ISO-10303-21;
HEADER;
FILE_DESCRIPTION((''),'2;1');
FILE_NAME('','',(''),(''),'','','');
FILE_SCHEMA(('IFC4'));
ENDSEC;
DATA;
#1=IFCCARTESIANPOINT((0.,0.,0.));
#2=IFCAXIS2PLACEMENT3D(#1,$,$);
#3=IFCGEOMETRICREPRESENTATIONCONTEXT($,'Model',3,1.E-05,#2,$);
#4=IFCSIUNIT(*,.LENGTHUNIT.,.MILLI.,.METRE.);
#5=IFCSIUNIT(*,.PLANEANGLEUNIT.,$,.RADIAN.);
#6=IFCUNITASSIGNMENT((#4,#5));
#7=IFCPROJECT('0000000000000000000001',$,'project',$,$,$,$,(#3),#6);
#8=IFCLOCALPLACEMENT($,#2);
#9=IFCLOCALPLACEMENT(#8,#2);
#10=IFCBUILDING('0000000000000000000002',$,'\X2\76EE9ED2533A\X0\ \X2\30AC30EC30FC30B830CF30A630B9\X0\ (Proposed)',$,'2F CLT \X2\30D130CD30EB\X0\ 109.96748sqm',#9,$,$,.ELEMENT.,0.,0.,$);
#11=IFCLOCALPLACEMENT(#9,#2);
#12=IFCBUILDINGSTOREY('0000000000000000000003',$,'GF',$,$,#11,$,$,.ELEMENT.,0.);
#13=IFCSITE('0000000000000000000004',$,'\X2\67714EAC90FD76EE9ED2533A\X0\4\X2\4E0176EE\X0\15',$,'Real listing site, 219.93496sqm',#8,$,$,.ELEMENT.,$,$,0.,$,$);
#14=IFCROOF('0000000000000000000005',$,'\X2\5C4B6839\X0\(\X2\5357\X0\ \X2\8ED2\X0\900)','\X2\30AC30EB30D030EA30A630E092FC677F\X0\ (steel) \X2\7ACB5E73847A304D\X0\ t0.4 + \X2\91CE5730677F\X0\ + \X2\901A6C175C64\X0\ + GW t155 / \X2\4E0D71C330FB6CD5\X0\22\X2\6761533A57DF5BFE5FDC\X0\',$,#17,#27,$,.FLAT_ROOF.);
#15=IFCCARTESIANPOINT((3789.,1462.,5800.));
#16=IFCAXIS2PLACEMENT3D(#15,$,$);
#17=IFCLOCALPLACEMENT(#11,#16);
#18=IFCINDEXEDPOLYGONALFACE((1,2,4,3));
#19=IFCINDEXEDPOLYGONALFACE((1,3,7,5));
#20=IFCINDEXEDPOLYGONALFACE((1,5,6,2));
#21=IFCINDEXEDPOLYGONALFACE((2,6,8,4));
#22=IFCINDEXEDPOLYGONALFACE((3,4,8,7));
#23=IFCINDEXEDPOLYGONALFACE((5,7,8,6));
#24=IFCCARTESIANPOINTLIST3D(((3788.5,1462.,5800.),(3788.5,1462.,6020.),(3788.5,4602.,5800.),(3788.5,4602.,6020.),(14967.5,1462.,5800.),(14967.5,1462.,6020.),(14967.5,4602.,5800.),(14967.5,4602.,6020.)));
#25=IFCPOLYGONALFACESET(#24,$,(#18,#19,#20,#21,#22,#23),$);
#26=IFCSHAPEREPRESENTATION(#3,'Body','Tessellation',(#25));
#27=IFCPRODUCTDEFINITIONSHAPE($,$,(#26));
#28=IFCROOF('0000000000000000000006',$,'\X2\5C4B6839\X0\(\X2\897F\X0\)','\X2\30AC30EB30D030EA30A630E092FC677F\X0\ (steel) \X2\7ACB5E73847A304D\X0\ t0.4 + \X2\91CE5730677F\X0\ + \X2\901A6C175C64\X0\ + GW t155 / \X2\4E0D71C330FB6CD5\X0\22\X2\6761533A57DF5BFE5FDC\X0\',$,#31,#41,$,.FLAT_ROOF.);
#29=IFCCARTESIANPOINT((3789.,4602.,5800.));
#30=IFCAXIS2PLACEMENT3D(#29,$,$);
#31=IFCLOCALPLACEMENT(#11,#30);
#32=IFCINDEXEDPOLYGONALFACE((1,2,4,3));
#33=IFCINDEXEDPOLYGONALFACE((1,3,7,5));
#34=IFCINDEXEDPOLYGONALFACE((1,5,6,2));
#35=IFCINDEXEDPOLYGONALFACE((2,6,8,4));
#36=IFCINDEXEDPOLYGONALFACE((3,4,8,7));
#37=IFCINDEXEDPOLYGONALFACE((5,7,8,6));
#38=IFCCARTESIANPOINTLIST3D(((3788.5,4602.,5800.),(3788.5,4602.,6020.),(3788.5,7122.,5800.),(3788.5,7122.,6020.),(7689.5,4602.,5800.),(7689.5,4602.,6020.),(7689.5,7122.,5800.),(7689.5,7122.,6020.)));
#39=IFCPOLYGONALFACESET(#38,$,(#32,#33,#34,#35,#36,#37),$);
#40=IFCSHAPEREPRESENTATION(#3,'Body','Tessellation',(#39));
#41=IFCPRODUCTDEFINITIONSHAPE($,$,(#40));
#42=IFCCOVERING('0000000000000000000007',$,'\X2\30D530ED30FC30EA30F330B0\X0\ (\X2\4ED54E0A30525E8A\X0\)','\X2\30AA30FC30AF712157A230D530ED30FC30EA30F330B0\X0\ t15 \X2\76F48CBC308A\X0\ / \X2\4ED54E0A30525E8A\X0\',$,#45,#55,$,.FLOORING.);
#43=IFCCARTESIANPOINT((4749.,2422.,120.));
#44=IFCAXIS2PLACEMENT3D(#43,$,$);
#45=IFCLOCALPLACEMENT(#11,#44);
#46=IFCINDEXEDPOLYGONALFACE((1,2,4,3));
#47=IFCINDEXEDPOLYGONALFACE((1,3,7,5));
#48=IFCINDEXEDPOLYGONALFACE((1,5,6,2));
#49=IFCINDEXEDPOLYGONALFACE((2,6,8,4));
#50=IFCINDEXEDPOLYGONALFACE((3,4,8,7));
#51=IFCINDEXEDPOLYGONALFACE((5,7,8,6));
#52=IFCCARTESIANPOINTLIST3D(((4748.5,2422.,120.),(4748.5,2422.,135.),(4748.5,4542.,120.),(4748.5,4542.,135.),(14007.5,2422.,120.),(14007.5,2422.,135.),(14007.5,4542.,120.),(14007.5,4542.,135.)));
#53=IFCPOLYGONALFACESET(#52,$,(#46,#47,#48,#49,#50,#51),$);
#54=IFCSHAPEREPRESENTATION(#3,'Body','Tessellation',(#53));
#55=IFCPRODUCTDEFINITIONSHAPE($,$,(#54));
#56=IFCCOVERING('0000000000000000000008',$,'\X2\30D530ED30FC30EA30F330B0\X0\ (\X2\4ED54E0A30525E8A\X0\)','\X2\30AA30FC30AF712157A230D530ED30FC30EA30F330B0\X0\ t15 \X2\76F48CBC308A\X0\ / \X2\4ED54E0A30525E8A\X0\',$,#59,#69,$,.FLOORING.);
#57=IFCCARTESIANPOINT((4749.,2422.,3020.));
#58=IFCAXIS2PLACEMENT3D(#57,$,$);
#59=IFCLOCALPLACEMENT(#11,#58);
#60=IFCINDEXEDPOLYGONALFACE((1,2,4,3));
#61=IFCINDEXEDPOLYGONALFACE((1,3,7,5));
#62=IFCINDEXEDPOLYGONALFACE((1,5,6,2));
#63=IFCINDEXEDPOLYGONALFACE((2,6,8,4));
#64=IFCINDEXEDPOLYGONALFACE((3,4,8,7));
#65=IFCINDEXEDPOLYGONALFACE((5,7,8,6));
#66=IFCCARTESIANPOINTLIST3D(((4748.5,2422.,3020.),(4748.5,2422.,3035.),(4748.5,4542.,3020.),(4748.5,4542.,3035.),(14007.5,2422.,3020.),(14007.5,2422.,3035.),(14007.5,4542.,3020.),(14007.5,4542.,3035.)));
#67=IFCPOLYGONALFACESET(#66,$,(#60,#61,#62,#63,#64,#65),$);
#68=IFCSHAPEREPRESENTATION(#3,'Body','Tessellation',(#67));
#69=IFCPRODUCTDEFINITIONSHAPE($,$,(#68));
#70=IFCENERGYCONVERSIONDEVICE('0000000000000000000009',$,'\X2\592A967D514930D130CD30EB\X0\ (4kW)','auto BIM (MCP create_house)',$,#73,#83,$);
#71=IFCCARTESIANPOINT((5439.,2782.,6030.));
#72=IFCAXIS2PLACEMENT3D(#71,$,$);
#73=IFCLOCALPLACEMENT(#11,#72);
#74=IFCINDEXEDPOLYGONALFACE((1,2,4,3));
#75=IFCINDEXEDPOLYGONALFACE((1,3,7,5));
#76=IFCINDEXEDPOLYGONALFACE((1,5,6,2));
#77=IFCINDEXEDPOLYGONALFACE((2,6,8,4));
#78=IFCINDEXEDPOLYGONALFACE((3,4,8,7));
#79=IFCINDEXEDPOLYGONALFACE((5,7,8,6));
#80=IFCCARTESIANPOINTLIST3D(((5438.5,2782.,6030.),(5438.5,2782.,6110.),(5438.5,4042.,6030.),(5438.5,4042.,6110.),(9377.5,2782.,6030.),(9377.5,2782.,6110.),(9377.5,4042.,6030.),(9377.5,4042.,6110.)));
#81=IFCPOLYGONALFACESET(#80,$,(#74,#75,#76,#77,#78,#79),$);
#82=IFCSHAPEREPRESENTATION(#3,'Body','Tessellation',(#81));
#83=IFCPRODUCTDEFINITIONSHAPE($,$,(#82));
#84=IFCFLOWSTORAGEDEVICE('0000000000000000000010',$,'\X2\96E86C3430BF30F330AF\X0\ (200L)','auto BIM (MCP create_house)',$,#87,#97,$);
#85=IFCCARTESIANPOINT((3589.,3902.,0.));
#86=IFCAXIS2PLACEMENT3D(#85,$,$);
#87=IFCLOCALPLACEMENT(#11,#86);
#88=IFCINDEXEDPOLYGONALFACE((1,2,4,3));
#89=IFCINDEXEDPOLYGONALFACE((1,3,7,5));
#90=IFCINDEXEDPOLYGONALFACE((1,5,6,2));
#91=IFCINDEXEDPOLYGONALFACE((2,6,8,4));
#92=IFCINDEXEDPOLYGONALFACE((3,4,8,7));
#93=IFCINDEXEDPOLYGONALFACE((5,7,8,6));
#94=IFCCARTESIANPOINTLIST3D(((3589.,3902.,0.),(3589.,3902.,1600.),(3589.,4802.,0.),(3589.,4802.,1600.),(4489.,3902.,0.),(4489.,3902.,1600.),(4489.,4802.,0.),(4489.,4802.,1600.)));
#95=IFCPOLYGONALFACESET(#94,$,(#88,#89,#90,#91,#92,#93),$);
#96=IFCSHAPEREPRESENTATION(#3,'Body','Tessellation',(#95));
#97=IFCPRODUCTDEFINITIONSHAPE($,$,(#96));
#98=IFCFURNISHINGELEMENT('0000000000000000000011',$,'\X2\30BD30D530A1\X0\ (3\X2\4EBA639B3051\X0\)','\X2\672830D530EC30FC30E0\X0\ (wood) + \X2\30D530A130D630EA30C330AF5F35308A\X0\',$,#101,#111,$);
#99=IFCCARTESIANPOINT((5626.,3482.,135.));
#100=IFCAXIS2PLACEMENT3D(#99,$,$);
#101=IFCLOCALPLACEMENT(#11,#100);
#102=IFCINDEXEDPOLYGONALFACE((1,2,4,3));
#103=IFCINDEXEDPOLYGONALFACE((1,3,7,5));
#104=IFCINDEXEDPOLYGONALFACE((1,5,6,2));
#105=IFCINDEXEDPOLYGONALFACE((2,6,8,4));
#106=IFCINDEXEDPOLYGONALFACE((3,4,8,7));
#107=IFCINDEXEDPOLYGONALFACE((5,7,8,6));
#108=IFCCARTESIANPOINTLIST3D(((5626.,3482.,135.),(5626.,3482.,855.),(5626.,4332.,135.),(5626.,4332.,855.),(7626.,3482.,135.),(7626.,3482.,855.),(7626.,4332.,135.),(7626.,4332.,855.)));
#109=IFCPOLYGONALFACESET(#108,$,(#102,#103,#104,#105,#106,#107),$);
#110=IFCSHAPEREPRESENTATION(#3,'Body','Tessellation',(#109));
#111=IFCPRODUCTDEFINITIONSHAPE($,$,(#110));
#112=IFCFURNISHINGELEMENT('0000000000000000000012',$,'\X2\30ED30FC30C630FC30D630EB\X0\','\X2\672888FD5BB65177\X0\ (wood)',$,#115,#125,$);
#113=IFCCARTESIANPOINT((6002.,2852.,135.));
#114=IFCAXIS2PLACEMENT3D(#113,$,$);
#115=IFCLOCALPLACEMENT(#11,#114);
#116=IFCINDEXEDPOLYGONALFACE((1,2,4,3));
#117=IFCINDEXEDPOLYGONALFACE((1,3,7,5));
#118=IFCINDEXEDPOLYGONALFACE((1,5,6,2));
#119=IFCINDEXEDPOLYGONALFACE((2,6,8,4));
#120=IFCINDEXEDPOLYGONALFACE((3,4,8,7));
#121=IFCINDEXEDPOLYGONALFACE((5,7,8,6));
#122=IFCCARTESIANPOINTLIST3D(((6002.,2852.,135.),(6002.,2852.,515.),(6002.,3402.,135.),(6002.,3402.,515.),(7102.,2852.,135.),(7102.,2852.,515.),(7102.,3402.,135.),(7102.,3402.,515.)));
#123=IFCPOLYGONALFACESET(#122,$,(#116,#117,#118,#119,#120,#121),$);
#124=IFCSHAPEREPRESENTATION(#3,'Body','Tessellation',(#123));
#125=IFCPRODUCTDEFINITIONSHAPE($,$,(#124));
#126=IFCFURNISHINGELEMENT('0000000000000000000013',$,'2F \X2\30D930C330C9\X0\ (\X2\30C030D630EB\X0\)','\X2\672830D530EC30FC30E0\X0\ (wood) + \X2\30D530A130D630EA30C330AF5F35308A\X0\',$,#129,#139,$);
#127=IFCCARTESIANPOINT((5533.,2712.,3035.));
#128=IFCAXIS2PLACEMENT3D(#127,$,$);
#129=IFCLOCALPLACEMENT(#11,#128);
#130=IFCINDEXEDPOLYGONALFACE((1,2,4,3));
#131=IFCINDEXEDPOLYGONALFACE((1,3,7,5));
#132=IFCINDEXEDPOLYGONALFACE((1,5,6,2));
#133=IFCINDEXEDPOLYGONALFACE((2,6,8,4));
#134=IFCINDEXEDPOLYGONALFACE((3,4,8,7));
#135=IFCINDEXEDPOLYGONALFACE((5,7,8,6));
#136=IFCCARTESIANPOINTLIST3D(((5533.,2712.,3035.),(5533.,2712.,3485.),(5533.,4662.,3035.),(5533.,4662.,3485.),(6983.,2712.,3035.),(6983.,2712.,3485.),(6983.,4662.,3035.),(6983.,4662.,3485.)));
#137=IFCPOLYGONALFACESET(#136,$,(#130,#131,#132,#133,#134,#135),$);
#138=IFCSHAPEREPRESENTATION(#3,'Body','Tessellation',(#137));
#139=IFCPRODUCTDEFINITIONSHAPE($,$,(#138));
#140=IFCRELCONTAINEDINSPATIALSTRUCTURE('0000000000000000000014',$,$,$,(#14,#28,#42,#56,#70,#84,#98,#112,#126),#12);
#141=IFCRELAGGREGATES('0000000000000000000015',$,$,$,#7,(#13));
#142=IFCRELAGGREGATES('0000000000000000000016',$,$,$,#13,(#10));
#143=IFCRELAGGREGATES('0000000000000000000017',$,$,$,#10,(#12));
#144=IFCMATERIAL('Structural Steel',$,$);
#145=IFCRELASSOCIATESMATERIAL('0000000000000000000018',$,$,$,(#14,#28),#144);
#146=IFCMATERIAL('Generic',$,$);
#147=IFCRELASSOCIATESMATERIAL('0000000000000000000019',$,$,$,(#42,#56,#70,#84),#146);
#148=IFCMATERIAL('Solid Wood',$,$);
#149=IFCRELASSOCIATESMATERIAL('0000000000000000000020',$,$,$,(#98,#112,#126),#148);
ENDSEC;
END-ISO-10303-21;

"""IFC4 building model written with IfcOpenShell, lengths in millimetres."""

from ifc_helpers import new_model, si_unit, frame, frame_2d, origin, place, context, project, spatial, rectangle, extrude, material, element, save


model = new_model("IFC4")

# Units and contexts
model_context = context("Model", 3, precision=1e-05, world=origin())
ifc_project = project(units=[si_unit("LENGTHUNIT", "METRE", prefix="MILLI"), si_unit("PLANEANGLEUNIT", "RADIAN")], contexts=[model_context])

# Site, building, storey
site_placement = place(None, origin())
site = spatial("IfcSite", under=ifc_project, at=site_placement, Name="東京都目黒区4丁目15", ObjectType="Real listing site, 219.93496sqm", CompositionType="ELEMENT", RefElevation=0.0)
building_placement = place(site_placement, origin())
building = spatial("IfcBuilding", under=site, at=building_placement, Name="目黒区 ガレージハウス (Proposed)", ObjectType="2F CLT パネル 109.96748sqm", CompositionType="ELEMENT", ElevationOfRefHeight=0.0, ElevationOfTerrain=0.0)
storey_placement = place(building_placement, origin())
storey = spatial("IfcBuildingStorey", under=building, at=storey_placement, Name="GF", CompositionType="ELEMENT", Elevation=0.0)

# Shared definitions
ifc_material_1 = material(Name="Solid Wood")

# Roofs
ifc_material_2 = material(Name="Structural Steel")
roof_1_placement = place(storey_placement, frame((3789.0, 1462.0, 5800.0)))
element("IfcRoof", 1, at=roof_1_placement, inside=storey, material=ifc_material_2, Name="屋根(南 軒900)", Description="ガルバリウム鋼板 (steel) 立平葺き t0.4 + 野地板 + 通気層 + GW t155 / 不燃・法22条区域対応", PredefinedType="FLAT_ROOF", context=model_context, shape_type="SweptSolid", body=[
    extrude(rectangle(XDim=11179.0, YDim=3140.0, at=frame_2d((5589.0, 1570.0))), frame((3789.0, 1462.0, 5800.0)), (0.0, 0.0, 1.0), 220.0),
])
roof_2_placement = place(storey_placement, frame((3789.0, 4602.0, 5800.0)))
element("IfcRoof", 2, at=roof_2_placement, inside=storey, material=ifc_material_2, Name="屋根(西)", Description="ガルバリウム鋼板 (steel) 立平葺き t0.4 + 野地板 + 通気層 + GW t155 / 不燃・法22条区域対応", PredefinedType="FLAT_ROOF", context=model_context, shape_type="SweptSolid", body=[
    extrude(rectangle(XDim=3901.0, YDim=2520.0, at=frame_2d((1950.0, 1260.0))), frame((3789.0, 4602.0, 5800.0)), (0.0, 0.0, 1.0), 220.0),
])

# Coverings
ifc_material_3 = material(Name="Generic")
covering_1_placement = place(storey_placement, frame((4749.0, 2422.0, 120.0)))
element("IfcCovering", 3, at=covering_1_placement, inside=storey, material=ifc_material_3, Name="フローリング (仕上げ床)", Description="オーク無垢フローリング t15 直貼り / 仕上げ床", PredefinedType="FLOORING", context=model_context, shape_type="SweptSolid", body=[
    extrude(rectangle(XDim=9259.0, YDim=2120.0, at=frame_2d((4629.0, 1060.0))), frame((4749.0, 2422.0, 120.0)), (0.0, 0.0, 1.0), 15.0),
])
covering_2_placement = place(storey_placement, frame((4749.0, 2422.0, 3020.0)))
element("IfcCovering", 4, at=covering_2_placement, inside=storey, material=ifc_material_3, Name="フローリング (仕上げ床)", Description="オーク無垢フローリング t15 直貼り / 仕上げ床", PredefinedType="FLOORING", context=model_context, shape_type="SweptSolid", body=[
    extrude(rectangle(XDim=9259.0, YDim=2120.0, at=frame_2d((4629.0, 1060.0))), frame((4749.0, 2422.0, 3020.0)), (0.0, 0.0, 1.0), 15.0),
])

# Energy conversion device
energy_conversion_device_placement = place(storey_placement, frame((5439.0, 2782.0, 6030.0)))
element("IfcEnergyConversionDevice", 5, at=energy_conversion_device_placement, inside=storey, material=ifc_material_3, Name="太陽光パネル (4kW)", Description="auto BIM (MCP create_house)", context=model_context, shape_type="SweptSolid", body=[
    extrude(rectangle(XDim=3939.0, YDim=1260.0, at=frame_2d((1969.0, 630.0))), frame((5439.0, 2782.0, 6030.0)), (0.0, 0.0, 1.0), 80.0),
])

# Flow storage device
flow_storage_device_placement = place(storey_placement, frame((3589.0, 3902.0, 0.0)))
element("IfcFlowStorageDevice", 6, at=flow_storage_device_placement, inside=storey, material=ifc_material_3, Name="雨水タンク (200L)", Description="auto BIM (MCP create_house)", context=model_context, shape_type="SweptSolid", body=[
    extrude(rectangle(XDim=900.0, YDim=900.0, at=frame_2d((450.0, 450.0))), frame((3589.0, 3902.0, 0.0)), (0.0, 0.0, 1.0), 1600.0),
])

# Furnishing elements
furnishing_1_placement = place(storey_placement, frame((5626.0, 3482.0, 135.0)))
element("IfcFurnishingElement", 7, at=furnishing_1_placement, inside=storey, material=ifc_material_1, Name="ソファ (3人掛け)", Description="木フレーム (wood) + ファブリック張り", context=model_context, shape_type="SweptSolid", body=[
    extrude(rectangle(XDim=2000.0, YDim=850.0, at=frame_2d((1000.0, 425.0))), frame((5626.0, 3482.0, 135.0)), (0.0, 0.0, 1.0), 720.0),
])
furnishing_2_placement = place(storey_placement, frame((6002.0, 2852.0, 135.0)))
element("IfcFurnishingElement", 8, at=furnishing_2_placement, inside=storey, material=ifc_material_1, Name="ローテーブル", Description="木製家具 (wood)", context=model_context, shape_type="SweptSolid", body=[
    extrude(rectangle(XDim=1100.0, YDim=550.0, at=frame_2d((550.0, 275.0))), frame((6002.0, 2852.0, 135.0)), (0.0, 0.0, 1.0), 380.0),
])
furnishing_3_placement = place(storey_placement, frame((5533.0, 2712.0, 3035.0)))
element("IfcFurnishingElement", 9, at=furnishing_3_placement, inside=storey, material=ifc_material_1, Name="2F ベッド (ダブル)", Description="木フレーム (wood) + ファブリック張り", context=model_context, shape_type="SweptSolid", body=[
    extrude(rectangle(XDim=1450.0, YDim=1950.0, at=frame_2d((725.0, 975.0))), frame((5533.0, 2712.0, 3035.0)), (0.0, 0.0, 1.0), 450.0),
])

save(model, "model.ifc")
